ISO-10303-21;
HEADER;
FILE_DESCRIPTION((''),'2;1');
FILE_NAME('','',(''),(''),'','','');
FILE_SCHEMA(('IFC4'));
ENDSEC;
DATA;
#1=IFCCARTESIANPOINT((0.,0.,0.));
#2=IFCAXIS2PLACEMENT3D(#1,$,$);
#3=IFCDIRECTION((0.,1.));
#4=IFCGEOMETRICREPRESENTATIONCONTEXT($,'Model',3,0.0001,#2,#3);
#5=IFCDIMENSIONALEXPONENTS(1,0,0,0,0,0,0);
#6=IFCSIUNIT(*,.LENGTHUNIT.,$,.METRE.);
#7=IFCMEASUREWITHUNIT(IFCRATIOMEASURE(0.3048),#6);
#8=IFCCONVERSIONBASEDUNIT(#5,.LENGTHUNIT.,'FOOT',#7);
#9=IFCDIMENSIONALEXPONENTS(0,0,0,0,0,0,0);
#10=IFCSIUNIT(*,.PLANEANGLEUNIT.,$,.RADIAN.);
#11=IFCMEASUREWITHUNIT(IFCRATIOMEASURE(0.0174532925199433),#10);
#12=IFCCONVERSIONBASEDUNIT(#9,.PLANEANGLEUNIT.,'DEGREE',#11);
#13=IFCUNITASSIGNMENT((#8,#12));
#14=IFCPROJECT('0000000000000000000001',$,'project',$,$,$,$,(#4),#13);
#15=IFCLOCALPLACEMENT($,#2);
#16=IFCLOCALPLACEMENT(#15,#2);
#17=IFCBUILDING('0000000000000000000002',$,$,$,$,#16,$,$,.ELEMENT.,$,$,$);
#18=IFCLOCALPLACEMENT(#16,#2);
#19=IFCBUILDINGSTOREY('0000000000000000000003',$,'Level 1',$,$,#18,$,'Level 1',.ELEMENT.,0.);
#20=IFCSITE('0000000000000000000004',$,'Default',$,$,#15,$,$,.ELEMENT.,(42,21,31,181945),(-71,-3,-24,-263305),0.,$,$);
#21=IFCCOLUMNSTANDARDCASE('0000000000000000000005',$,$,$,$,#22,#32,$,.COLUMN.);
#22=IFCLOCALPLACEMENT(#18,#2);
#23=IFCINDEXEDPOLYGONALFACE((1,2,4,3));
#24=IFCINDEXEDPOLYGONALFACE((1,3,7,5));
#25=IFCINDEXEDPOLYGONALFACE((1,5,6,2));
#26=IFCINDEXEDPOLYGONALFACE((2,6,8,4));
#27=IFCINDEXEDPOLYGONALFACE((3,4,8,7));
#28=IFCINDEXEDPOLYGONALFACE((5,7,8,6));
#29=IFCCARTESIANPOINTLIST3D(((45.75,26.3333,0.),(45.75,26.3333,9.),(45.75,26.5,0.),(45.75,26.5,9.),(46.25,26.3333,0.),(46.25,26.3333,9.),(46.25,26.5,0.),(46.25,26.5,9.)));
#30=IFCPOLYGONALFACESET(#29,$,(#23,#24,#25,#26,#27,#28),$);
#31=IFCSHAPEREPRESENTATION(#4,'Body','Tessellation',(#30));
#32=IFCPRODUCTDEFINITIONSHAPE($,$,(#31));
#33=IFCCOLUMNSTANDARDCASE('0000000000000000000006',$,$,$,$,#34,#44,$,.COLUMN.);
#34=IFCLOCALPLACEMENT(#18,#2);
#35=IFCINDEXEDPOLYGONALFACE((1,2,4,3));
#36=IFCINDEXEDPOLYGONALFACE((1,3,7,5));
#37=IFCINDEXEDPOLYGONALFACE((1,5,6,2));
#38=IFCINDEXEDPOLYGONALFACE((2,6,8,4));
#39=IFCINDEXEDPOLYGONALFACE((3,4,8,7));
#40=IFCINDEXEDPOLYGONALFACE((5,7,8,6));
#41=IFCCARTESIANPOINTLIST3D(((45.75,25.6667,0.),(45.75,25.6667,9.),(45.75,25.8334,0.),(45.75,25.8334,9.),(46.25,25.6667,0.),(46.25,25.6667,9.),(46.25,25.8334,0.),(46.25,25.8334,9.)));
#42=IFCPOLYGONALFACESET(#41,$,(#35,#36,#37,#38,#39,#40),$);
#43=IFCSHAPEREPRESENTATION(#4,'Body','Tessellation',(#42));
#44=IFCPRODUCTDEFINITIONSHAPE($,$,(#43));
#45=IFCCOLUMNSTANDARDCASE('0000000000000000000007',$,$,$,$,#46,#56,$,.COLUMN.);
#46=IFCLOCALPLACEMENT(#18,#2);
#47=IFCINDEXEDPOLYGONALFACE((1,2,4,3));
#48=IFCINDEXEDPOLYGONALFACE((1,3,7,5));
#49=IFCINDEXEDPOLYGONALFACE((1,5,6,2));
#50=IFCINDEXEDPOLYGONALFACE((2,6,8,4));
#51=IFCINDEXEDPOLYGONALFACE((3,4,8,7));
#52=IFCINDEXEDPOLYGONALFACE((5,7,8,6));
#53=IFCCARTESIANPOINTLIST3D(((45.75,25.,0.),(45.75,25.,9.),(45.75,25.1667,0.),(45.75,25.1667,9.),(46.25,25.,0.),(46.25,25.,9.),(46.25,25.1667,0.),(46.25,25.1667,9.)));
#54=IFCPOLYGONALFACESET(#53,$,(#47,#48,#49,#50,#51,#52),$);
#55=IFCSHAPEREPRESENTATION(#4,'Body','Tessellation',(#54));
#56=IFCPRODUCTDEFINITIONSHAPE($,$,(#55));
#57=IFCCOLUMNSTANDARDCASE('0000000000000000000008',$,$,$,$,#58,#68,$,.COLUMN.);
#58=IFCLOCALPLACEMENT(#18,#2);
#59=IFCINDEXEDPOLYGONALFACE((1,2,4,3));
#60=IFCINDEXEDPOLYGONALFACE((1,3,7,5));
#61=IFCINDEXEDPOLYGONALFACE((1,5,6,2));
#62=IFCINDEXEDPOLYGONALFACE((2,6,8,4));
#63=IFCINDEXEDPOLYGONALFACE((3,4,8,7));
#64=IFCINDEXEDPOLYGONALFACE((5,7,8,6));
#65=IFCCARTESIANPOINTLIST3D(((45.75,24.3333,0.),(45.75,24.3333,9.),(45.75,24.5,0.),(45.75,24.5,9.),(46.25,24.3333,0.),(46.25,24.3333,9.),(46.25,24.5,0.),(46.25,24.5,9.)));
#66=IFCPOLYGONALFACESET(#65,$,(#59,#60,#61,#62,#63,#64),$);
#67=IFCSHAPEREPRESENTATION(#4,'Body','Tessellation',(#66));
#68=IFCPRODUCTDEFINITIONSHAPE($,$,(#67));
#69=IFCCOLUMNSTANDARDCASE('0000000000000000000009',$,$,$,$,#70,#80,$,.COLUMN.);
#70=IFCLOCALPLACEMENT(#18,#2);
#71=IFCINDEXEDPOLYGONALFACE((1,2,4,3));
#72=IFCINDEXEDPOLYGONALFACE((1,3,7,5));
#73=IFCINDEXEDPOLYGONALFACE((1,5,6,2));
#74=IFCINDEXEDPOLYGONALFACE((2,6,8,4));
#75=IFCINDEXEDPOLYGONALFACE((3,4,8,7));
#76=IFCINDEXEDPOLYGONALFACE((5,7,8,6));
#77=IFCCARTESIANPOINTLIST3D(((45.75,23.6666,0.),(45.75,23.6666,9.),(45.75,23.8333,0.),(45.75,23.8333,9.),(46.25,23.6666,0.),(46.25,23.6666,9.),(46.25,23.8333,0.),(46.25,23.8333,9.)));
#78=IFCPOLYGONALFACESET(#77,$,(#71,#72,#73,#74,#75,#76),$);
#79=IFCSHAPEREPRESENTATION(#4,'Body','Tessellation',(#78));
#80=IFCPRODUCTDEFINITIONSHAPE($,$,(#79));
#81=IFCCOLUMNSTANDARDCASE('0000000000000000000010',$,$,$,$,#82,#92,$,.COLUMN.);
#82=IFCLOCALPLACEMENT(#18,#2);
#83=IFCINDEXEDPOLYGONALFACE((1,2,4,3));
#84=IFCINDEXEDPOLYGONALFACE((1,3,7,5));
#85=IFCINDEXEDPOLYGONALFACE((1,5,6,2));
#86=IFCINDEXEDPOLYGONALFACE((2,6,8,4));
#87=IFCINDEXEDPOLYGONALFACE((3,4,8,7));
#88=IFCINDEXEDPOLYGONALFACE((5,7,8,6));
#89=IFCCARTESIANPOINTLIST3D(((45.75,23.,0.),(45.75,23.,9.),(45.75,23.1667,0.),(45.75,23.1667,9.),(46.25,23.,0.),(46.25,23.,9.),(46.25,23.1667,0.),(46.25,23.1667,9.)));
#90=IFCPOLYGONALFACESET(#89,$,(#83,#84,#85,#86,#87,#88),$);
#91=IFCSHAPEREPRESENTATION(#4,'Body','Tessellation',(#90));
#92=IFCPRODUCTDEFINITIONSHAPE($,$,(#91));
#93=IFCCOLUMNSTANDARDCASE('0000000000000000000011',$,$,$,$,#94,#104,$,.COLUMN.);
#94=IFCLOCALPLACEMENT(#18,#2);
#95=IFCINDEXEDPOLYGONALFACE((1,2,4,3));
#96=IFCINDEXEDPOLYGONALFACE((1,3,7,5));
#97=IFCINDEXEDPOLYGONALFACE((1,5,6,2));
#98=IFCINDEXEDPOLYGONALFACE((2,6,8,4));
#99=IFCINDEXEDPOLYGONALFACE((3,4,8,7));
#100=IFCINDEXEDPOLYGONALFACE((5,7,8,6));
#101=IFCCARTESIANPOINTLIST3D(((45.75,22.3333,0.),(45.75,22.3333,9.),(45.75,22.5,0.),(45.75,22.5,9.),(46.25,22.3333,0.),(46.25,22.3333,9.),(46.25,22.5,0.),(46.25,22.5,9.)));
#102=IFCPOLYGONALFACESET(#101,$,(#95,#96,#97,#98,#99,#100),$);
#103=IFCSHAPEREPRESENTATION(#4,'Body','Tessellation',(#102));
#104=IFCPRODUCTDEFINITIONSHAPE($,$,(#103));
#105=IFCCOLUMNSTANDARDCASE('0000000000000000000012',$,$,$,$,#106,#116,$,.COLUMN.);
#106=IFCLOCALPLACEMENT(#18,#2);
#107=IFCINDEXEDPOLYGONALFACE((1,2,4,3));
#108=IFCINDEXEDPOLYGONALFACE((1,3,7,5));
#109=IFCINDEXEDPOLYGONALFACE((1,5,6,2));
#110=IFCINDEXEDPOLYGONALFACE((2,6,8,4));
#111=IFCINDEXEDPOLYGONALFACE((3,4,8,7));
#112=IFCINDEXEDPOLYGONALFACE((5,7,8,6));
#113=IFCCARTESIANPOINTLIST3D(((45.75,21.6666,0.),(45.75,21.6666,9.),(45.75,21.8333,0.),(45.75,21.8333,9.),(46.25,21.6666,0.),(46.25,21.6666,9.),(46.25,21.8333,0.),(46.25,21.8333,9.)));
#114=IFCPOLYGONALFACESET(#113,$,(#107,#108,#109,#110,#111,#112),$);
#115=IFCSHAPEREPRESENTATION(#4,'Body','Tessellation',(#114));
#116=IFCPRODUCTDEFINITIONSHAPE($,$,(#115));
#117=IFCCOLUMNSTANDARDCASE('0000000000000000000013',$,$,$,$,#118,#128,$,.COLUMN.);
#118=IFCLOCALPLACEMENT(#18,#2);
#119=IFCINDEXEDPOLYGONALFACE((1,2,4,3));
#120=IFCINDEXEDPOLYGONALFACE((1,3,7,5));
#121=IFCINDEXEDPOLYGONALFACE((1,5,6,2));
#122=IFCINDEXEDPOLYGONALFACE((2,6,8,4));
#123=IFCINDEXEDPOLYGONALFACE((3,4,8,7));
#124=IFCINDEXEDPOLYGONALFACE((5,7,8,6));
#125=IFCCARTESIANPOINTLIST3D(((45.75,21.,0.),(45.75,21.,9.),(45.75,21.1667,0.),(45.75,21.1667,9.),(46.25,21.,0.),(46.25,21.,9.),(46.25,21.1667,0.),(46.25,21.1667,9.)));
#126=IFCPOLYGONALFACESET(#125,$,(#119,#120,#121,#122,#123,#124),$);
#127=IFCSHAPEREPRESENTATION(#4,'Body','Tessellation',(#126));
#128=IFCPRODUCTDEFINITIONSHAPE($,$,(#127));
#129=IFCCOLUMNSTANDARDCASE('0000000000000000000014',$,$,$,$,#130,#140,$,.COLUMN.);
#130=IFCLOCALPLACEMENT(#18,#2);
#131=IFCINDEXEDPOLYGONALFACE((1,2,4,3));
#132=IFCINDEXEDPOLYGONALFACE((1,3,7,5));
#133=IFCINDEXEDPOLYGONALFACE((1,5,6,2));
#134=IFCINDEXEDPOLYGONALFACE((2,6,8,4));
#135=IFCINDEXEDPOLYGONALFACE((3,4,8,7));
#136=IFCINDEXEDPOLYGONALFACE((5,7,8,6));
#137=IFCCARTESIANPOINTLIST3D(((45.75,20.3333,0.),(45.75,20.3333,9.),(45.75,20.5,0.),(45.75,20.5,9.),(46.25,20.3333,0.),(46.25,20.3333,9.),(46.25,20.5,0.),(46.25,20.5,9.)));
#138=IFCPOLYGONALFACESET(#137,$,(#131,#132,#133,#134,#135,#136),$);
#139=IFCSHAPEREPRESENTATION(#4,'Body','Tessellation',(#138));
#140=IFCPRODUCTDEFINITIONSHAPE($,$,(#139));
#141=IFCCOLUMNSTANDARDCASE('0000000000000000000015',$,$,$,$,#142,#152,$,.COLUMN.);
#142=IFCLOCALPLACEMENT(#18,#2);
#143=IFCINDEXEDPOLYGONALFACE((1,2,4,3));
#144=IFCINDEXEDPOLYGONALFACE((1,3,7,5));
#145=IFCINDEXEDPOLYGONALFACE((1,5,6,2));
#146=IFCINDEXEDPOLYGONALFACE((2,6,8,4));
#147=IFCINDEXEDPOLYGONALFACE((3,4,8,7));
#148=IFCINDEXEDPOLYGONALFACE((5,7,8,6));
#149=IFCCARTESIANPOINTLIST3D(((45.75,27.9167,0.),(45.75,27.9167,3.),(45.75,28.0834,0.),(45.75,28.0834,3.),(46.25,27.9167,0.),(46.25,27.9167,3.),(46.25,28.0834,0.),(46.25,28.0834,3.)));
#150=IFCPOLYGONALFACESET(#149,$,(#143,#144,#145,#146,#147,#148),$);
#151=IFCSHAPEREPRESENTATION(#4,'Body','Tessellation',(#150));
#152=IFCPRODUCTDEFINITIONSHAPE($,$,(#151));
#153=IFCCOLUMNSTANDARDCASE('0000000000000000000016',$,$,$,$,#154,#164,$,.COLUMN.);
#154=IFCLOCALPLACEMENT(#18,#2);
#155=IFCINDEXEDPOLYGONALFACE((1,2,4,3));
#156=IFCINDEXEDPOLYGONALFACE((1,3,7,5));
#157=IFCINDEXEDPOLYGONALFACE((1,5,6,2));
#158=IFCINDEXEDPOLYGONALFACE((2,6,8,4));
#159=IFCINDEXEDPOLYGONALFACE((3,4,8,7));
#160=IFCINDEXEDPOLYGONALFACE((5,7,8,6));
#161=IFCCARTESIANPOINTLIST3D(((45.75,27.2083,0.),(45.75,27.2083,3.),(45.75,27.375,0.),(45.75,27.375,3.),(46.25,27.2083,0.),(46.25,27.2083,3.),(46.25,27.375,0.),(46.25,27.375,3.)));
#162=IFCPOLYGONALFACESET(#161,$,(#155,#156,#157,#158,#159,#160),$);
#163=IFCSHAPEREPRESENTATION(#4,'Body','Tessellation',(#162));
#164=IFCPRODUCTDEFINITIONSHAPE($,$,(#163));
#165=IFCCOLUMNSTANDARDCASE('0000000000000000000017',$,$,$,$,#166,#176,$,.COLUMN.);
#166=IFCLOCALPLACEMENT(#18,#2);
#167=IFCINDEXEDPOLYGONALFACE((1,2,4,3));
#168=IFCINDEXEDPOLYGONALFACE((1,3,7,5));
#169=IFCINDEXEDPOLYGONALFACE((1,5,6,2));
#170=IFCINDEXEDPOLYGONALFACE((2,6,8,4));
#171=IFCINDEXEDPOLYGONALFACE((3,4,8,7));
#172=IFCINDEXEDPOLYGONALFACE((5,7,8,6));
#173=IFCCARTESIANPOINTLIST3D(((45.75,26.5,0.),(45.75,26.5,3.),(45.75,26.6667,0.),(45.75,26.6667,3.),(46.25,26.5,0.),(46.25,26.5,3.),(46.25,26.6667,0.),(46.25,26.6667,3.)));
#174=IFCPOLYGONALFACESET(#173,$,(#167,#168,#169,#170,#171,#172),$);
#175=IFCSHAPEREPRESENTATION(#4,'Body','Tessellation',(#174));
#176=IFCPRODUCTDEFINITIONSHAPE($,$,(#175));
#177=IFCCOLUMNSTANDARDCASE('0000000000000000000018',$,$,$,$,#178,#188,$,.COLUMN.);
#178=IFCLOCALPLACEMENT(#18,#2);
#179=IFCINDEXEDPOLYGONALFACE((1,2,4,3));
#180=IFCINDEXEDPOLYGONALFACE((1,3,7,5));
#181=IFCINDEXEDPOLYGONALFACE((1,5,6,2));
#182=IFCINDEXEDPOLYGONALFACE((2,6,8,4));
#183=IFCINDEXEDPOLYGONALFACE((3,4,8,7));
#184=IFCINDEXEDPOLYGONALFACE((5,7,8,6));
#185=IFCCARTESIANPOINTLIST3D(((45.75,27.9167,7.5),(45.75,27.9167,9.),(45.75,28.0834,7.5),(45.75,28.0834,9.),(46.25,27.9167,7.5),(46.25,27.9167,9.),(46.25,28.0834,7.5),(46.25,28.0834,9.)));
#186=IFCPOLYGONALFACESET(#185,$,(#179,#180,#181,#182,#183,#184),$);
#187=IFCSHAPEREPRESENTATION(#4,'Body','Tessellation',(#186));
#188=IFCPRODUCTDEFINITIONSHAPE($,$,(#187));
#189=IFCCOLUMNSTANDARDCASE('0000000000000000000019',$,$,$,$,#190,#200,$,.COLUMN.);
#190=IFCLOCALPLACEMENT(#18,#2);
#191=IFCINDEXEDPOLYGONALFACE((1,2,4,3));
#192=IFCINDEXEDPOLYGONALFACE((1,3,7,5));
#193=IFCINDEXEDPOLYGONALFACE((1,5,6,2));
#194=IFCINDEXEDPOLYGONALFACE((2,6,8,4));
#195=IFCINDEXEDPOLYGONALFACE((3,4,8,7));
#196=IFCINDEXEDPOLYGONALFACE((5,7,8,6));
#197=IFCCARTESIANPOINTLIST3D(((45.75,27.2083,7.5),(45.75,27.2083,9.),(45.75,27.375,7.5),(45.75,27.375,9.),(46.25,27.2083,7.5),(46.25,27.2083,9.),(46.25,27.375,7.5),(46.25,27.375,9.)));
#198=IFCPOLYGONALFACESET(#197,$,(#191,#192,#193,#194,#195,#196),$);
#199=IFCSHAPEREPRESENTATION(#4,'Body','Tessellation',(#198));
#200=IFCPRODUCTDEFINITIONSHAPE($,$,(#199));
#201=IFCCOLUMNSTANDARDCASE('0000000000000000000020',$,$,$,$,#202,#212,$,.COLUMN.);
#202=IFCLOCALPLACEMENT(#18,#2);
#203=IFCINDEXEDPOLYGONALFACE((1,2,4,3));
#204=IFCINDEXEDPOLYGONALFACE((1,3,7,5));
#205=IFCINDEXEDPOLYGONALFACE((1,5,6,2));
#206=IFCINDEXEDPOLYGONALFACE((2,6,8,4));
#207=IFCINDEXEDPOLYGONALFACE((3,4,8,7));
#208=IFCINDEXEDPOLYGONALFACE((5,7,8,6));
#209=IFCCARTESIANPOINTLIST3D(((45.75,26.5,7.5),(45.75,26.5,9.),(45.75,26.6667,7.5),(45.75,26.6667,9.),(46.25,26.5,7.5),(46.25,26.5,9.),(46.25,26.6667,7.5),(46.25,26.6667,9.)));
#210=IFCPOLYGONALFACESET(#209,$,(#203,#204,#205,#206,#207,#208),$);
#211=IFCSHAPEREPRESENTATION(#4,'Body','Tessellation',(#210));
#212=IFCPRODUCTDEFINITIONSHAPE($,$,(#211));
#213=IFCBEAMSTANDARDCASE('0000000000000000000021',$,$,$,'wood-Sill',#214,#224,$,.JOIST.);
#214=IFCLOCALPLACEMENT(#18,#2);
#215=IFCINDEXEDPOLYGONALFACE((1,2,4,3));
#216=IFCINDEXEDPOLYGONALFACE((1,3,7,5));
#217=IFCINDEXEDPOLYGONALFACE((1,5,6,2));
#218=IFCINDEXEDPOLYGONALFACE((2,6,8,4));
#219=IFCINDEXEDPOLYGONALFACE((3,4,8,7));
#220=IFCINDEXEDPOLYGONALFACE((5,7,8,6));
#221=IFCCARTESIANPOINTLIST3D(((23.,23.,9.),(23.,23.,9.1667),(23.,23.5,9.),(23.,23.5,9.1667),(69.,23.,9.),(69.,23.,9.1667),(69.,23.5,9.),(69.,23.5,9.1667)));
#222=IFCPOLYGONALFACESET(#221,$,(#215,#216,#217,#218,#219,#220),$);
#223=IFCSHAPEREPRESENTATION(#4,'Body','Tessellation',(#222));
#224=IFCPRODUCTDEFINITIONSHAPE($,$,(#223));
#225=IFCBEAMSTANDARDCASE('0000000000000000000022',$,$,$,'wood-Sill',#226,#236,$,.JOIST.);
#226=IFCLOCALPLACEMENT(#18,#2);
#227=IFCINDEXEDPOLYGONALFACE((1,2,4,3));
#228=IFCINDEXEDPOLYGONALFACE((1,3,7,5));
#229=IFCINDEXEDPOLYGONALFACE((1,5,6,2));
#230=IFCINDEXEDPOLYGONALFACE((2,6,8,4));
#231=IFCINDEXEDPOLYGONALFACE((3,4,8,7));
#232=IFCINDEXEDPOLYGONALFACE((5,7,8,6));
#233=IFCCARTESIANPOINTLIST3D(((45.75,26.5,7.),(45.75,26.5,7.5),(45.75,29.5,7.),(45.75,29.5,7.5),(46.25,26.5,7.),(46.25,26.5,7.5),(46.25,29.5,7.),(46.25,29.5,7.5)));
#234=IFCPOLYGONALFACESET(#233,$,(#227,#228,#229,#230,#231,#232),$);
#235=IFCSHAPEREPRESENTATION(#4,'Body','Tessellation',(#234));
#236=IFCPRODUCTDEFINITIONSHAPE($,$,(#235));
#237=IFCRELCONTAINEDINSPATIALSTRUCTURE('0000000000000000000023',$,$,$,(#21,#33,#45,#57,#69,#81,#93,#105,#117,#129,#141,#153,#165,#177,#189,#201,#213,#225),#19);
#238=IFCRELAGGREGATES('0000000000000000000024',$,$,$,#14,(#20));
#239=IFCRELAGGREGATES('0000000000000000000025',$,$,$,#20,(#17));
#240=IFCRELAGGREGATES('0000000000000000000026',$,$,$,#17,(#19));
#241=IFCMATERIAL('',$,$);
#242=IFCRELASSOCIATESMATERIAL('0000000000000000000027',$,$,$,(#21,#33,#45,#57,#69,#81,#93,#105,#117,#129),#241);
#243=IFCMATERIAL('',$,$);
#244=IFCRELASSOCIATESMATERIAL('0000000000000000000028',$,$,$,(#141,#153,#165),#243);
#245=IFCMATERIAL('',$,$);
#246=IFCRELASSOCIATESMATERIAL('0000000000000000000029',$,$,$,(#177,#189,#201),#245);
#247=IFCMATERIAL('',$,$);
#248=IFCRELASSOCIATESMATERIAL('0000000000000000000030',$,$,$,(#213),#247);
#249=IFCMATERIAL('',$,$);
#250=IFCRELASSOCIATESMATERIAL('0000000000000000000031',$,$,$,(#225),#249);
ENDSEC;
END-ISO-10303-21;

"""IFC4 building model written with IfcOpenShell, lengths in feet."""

from ifc_helpers import new_model, entity, si_unit, converted_unit, direction, frame, origin, place, context, project, spatial, rectangle, extrude, material, element, save


model = new_model("IFC4")

# Units and contexts
model_context = context("Model", 3, precision=0.0001, world=origin(), true_north=direction((0.0, 1.0)))
ifc_project = project(units=[converted_unit("LENGTHUNIT", "FOOT", entity("IfcRatioMeasure", 0.3048), si_unit("LENGTHUNIT", "METRE"), dimensions=[1, 0, 0, 0, 0, 0, 0]), converted_unit("PLANEANGLEUNIT", "DEGREE", entity("IfcRatioMeasure", 0.0174532925199433), si_unit("PLANEANGLEUNIT", "RADIAN"), dimensions=[0, 0, 0, 0, 0, 0, 0])], contexts=[model_context])

# Site, building, storey
site_placement = place(None, origin())
site = spatial("IfcSite", under=ifc_project, at=site_placement, Name="Default", CompositionType="ELEMENT", RefLatitude=(42, 21, 31, 181945), RefLongitude=(-71, -3, -24, -263305), RefElevation=0.0)
building_placement = place(site_placement, origin())
building = spatial("IfcBuilding", under=site, at=building_placement, CompositionType="ELEMENT")
storey_placement = place(building_placement, origin())
storey = spatial("IfcBuildingStorey", under=building, at=storey_placement, Name="Level 1", LongName="Level 1", CompositionType="ELEMENT", Elevation=0.0)

# Columns
ifc_material_1 = material(Name="")
placement_1 = place(storey_placement, frame((46.0, 46.25, 0.0), z_axis=(0.0, 0.0, 1.0), x_axis=(0.0, -1.0, 0.0)))
for number, where, z_axis, x_axis in (
    (1, (19.8334, 0.0, 0.0), (0.0, 0.0, 1.0), (1.0, 0.0, 0.0)),
    (2, (20.5, 0.0, 0.0), (0.0, 0.0, 1.0), (1.0, 0.0, 0.0)),
    (3, (21.1667, 0.0, 0.0), (0.0, 0.0, 1.0), (1.0, 0.0, 0.0)),
    (4, (21.8334, 0.0, 0.0), (0.0, 0.0, 1.0), (1.0, 0.0, 0.0)),
    (5, (22.5001, 0.0, 0.0), (0.0, 0.0, 1.0), (1.0, 0.0, 0.0)),
    (6, (23.1667, 0.0, 0.0), (0.0, 0.0, 1.0), (1.0, 0.0, 0.0)),
    (7, (23.8334, 0.0, 0.0), (0.0, 0.0, 1.0), (1.0, 0.0, 0.0)),
    (8, (24.5001, 0.0, 0.0), (0.0, 0.0, 1.0), (1.0, 0.0, 0.0)),
    (9, (25.1667, 0.0, 0.0), (0.0, 0.0, 1.0), (1.0, 0.0, 0.0)),
    (10, (25.8334, 0.0, 0.0), (0.0, 0.0, 1.0), (1.0, 0.0, 0.0)),
):
    element("IfcColumnStandardCase", number, at=place(placement_1, frame(where, z_axis=z_axis, x_axis=x_axis)), inside=storey, material=ifc_material_1, PredefinedType="COLUMN", context=model_context, shape_type="SweptSolid", body=[
        extrude(rectangle(XDim=0.1667, YDim=0.5), origin(), (0.0, 0.0, 1.0), 9.0),
    ])
ifc_material_2 = material(Name="")
for number, where, z_axis, x_axis in (
    (11, (18.25, 0.0, 0.0), (0.0, 0.0, 1.0), (1.0, 0.0, 0.0)),
    (12, (18.9584, 0.0, 0.0), (0.0, 0.0, 1.0), (1.0, 0.0, 0.0)),
    (13, (19.6667, 0.0, 0.0), (0.0, 0.0, 1.0), (1.0, 0.0, 0.0)),
):
    element("IfcColumnStandardCase", number, at=place(placement_1, frame(where, z_axis=z_axis, x_axis=x_axis)), inside=storey, material=ifc_material_2, PredefinedType="COLUMN", context=model_context, shape_type="SweptSolid", body=[
        extrude(rectangle(XDim=0.1667, YDim=0.5), origin(), (0.0, 0.0, 1.0), 3.0),
    ])
ifc_material_3 = material(Name="")
for number, where, z_axis, x_axis in (
    (14, (18.25, 0.0, 7.5), (0.0, 0.0, 1.0), (1.0, 0.0, 0.0)),
    (15, (18.9584, 0.0, 7.5), (0.0, 0.0, 1.0), (1.0, 0.0, 0.0)),
    (16, (19.6667, 0.0, 7.5), (0.0, 0.0, 1.0), (1.0, 0.0, 0.0)),
):
    element("IfcColumnStandardCase", number, at=place(placement_1, frame(where, z_axis=z_axis, x_axis=x_axis)), inside=storey, material=ifc_material_3, PredefinedType="COLUMN", context=model_context, shape_type="SweptSolid", body=[
        extrude(rectangle(XDim=0.1667, YDim=0.5), origin(), (0.0, 0.0, 1.0), 1.5),
    ])

# Beams
ifc_material_4 = material(Name="")
beam_1_placement = place(placement_1, frame((23.0, 0.0, 9.0), z_axis=(0.0, 0.0, 1.0), x_axis=(0.0, -1.0, 0.0)))
element("IfcBeamStandardCase", 17, at=beam_1_placement, inside=storey, material=ifc_material_4, ObjectType="wood-Sill", PredefinedType="JOIST", context=model_context, shape_type="SweptSolid", body=[
    extrude(rectangle(XDim=46.0, YDim=0.5), origin(), (0.0, 0.0, 1.0), 0.1667),
])
ifc_material_5 = material(Name="")
for number, where, z_axis, x_axis in (
    (18, (18.25, 0.0, 7.0), (0.0, 0.0, 1.0), (-1.0, 0.0, 0.0)),
):
    element("IfcBeamStandardCase", number, at=place(placement_1, frame(where, z_axis=z_axis, x_axis=x_axis)), inside=storey, material=ifc_material_5, ObjectType="wood-Sill", PredefinedType="JOIST", context=model_context, shape_type="SweptSolid", body=[
        extrude(rectangle(XDim=3.0, YDim=0.5), origin(), (0.0, 0.0, 1.0), 0.5),
    ])

save(model, "model.ifc")
